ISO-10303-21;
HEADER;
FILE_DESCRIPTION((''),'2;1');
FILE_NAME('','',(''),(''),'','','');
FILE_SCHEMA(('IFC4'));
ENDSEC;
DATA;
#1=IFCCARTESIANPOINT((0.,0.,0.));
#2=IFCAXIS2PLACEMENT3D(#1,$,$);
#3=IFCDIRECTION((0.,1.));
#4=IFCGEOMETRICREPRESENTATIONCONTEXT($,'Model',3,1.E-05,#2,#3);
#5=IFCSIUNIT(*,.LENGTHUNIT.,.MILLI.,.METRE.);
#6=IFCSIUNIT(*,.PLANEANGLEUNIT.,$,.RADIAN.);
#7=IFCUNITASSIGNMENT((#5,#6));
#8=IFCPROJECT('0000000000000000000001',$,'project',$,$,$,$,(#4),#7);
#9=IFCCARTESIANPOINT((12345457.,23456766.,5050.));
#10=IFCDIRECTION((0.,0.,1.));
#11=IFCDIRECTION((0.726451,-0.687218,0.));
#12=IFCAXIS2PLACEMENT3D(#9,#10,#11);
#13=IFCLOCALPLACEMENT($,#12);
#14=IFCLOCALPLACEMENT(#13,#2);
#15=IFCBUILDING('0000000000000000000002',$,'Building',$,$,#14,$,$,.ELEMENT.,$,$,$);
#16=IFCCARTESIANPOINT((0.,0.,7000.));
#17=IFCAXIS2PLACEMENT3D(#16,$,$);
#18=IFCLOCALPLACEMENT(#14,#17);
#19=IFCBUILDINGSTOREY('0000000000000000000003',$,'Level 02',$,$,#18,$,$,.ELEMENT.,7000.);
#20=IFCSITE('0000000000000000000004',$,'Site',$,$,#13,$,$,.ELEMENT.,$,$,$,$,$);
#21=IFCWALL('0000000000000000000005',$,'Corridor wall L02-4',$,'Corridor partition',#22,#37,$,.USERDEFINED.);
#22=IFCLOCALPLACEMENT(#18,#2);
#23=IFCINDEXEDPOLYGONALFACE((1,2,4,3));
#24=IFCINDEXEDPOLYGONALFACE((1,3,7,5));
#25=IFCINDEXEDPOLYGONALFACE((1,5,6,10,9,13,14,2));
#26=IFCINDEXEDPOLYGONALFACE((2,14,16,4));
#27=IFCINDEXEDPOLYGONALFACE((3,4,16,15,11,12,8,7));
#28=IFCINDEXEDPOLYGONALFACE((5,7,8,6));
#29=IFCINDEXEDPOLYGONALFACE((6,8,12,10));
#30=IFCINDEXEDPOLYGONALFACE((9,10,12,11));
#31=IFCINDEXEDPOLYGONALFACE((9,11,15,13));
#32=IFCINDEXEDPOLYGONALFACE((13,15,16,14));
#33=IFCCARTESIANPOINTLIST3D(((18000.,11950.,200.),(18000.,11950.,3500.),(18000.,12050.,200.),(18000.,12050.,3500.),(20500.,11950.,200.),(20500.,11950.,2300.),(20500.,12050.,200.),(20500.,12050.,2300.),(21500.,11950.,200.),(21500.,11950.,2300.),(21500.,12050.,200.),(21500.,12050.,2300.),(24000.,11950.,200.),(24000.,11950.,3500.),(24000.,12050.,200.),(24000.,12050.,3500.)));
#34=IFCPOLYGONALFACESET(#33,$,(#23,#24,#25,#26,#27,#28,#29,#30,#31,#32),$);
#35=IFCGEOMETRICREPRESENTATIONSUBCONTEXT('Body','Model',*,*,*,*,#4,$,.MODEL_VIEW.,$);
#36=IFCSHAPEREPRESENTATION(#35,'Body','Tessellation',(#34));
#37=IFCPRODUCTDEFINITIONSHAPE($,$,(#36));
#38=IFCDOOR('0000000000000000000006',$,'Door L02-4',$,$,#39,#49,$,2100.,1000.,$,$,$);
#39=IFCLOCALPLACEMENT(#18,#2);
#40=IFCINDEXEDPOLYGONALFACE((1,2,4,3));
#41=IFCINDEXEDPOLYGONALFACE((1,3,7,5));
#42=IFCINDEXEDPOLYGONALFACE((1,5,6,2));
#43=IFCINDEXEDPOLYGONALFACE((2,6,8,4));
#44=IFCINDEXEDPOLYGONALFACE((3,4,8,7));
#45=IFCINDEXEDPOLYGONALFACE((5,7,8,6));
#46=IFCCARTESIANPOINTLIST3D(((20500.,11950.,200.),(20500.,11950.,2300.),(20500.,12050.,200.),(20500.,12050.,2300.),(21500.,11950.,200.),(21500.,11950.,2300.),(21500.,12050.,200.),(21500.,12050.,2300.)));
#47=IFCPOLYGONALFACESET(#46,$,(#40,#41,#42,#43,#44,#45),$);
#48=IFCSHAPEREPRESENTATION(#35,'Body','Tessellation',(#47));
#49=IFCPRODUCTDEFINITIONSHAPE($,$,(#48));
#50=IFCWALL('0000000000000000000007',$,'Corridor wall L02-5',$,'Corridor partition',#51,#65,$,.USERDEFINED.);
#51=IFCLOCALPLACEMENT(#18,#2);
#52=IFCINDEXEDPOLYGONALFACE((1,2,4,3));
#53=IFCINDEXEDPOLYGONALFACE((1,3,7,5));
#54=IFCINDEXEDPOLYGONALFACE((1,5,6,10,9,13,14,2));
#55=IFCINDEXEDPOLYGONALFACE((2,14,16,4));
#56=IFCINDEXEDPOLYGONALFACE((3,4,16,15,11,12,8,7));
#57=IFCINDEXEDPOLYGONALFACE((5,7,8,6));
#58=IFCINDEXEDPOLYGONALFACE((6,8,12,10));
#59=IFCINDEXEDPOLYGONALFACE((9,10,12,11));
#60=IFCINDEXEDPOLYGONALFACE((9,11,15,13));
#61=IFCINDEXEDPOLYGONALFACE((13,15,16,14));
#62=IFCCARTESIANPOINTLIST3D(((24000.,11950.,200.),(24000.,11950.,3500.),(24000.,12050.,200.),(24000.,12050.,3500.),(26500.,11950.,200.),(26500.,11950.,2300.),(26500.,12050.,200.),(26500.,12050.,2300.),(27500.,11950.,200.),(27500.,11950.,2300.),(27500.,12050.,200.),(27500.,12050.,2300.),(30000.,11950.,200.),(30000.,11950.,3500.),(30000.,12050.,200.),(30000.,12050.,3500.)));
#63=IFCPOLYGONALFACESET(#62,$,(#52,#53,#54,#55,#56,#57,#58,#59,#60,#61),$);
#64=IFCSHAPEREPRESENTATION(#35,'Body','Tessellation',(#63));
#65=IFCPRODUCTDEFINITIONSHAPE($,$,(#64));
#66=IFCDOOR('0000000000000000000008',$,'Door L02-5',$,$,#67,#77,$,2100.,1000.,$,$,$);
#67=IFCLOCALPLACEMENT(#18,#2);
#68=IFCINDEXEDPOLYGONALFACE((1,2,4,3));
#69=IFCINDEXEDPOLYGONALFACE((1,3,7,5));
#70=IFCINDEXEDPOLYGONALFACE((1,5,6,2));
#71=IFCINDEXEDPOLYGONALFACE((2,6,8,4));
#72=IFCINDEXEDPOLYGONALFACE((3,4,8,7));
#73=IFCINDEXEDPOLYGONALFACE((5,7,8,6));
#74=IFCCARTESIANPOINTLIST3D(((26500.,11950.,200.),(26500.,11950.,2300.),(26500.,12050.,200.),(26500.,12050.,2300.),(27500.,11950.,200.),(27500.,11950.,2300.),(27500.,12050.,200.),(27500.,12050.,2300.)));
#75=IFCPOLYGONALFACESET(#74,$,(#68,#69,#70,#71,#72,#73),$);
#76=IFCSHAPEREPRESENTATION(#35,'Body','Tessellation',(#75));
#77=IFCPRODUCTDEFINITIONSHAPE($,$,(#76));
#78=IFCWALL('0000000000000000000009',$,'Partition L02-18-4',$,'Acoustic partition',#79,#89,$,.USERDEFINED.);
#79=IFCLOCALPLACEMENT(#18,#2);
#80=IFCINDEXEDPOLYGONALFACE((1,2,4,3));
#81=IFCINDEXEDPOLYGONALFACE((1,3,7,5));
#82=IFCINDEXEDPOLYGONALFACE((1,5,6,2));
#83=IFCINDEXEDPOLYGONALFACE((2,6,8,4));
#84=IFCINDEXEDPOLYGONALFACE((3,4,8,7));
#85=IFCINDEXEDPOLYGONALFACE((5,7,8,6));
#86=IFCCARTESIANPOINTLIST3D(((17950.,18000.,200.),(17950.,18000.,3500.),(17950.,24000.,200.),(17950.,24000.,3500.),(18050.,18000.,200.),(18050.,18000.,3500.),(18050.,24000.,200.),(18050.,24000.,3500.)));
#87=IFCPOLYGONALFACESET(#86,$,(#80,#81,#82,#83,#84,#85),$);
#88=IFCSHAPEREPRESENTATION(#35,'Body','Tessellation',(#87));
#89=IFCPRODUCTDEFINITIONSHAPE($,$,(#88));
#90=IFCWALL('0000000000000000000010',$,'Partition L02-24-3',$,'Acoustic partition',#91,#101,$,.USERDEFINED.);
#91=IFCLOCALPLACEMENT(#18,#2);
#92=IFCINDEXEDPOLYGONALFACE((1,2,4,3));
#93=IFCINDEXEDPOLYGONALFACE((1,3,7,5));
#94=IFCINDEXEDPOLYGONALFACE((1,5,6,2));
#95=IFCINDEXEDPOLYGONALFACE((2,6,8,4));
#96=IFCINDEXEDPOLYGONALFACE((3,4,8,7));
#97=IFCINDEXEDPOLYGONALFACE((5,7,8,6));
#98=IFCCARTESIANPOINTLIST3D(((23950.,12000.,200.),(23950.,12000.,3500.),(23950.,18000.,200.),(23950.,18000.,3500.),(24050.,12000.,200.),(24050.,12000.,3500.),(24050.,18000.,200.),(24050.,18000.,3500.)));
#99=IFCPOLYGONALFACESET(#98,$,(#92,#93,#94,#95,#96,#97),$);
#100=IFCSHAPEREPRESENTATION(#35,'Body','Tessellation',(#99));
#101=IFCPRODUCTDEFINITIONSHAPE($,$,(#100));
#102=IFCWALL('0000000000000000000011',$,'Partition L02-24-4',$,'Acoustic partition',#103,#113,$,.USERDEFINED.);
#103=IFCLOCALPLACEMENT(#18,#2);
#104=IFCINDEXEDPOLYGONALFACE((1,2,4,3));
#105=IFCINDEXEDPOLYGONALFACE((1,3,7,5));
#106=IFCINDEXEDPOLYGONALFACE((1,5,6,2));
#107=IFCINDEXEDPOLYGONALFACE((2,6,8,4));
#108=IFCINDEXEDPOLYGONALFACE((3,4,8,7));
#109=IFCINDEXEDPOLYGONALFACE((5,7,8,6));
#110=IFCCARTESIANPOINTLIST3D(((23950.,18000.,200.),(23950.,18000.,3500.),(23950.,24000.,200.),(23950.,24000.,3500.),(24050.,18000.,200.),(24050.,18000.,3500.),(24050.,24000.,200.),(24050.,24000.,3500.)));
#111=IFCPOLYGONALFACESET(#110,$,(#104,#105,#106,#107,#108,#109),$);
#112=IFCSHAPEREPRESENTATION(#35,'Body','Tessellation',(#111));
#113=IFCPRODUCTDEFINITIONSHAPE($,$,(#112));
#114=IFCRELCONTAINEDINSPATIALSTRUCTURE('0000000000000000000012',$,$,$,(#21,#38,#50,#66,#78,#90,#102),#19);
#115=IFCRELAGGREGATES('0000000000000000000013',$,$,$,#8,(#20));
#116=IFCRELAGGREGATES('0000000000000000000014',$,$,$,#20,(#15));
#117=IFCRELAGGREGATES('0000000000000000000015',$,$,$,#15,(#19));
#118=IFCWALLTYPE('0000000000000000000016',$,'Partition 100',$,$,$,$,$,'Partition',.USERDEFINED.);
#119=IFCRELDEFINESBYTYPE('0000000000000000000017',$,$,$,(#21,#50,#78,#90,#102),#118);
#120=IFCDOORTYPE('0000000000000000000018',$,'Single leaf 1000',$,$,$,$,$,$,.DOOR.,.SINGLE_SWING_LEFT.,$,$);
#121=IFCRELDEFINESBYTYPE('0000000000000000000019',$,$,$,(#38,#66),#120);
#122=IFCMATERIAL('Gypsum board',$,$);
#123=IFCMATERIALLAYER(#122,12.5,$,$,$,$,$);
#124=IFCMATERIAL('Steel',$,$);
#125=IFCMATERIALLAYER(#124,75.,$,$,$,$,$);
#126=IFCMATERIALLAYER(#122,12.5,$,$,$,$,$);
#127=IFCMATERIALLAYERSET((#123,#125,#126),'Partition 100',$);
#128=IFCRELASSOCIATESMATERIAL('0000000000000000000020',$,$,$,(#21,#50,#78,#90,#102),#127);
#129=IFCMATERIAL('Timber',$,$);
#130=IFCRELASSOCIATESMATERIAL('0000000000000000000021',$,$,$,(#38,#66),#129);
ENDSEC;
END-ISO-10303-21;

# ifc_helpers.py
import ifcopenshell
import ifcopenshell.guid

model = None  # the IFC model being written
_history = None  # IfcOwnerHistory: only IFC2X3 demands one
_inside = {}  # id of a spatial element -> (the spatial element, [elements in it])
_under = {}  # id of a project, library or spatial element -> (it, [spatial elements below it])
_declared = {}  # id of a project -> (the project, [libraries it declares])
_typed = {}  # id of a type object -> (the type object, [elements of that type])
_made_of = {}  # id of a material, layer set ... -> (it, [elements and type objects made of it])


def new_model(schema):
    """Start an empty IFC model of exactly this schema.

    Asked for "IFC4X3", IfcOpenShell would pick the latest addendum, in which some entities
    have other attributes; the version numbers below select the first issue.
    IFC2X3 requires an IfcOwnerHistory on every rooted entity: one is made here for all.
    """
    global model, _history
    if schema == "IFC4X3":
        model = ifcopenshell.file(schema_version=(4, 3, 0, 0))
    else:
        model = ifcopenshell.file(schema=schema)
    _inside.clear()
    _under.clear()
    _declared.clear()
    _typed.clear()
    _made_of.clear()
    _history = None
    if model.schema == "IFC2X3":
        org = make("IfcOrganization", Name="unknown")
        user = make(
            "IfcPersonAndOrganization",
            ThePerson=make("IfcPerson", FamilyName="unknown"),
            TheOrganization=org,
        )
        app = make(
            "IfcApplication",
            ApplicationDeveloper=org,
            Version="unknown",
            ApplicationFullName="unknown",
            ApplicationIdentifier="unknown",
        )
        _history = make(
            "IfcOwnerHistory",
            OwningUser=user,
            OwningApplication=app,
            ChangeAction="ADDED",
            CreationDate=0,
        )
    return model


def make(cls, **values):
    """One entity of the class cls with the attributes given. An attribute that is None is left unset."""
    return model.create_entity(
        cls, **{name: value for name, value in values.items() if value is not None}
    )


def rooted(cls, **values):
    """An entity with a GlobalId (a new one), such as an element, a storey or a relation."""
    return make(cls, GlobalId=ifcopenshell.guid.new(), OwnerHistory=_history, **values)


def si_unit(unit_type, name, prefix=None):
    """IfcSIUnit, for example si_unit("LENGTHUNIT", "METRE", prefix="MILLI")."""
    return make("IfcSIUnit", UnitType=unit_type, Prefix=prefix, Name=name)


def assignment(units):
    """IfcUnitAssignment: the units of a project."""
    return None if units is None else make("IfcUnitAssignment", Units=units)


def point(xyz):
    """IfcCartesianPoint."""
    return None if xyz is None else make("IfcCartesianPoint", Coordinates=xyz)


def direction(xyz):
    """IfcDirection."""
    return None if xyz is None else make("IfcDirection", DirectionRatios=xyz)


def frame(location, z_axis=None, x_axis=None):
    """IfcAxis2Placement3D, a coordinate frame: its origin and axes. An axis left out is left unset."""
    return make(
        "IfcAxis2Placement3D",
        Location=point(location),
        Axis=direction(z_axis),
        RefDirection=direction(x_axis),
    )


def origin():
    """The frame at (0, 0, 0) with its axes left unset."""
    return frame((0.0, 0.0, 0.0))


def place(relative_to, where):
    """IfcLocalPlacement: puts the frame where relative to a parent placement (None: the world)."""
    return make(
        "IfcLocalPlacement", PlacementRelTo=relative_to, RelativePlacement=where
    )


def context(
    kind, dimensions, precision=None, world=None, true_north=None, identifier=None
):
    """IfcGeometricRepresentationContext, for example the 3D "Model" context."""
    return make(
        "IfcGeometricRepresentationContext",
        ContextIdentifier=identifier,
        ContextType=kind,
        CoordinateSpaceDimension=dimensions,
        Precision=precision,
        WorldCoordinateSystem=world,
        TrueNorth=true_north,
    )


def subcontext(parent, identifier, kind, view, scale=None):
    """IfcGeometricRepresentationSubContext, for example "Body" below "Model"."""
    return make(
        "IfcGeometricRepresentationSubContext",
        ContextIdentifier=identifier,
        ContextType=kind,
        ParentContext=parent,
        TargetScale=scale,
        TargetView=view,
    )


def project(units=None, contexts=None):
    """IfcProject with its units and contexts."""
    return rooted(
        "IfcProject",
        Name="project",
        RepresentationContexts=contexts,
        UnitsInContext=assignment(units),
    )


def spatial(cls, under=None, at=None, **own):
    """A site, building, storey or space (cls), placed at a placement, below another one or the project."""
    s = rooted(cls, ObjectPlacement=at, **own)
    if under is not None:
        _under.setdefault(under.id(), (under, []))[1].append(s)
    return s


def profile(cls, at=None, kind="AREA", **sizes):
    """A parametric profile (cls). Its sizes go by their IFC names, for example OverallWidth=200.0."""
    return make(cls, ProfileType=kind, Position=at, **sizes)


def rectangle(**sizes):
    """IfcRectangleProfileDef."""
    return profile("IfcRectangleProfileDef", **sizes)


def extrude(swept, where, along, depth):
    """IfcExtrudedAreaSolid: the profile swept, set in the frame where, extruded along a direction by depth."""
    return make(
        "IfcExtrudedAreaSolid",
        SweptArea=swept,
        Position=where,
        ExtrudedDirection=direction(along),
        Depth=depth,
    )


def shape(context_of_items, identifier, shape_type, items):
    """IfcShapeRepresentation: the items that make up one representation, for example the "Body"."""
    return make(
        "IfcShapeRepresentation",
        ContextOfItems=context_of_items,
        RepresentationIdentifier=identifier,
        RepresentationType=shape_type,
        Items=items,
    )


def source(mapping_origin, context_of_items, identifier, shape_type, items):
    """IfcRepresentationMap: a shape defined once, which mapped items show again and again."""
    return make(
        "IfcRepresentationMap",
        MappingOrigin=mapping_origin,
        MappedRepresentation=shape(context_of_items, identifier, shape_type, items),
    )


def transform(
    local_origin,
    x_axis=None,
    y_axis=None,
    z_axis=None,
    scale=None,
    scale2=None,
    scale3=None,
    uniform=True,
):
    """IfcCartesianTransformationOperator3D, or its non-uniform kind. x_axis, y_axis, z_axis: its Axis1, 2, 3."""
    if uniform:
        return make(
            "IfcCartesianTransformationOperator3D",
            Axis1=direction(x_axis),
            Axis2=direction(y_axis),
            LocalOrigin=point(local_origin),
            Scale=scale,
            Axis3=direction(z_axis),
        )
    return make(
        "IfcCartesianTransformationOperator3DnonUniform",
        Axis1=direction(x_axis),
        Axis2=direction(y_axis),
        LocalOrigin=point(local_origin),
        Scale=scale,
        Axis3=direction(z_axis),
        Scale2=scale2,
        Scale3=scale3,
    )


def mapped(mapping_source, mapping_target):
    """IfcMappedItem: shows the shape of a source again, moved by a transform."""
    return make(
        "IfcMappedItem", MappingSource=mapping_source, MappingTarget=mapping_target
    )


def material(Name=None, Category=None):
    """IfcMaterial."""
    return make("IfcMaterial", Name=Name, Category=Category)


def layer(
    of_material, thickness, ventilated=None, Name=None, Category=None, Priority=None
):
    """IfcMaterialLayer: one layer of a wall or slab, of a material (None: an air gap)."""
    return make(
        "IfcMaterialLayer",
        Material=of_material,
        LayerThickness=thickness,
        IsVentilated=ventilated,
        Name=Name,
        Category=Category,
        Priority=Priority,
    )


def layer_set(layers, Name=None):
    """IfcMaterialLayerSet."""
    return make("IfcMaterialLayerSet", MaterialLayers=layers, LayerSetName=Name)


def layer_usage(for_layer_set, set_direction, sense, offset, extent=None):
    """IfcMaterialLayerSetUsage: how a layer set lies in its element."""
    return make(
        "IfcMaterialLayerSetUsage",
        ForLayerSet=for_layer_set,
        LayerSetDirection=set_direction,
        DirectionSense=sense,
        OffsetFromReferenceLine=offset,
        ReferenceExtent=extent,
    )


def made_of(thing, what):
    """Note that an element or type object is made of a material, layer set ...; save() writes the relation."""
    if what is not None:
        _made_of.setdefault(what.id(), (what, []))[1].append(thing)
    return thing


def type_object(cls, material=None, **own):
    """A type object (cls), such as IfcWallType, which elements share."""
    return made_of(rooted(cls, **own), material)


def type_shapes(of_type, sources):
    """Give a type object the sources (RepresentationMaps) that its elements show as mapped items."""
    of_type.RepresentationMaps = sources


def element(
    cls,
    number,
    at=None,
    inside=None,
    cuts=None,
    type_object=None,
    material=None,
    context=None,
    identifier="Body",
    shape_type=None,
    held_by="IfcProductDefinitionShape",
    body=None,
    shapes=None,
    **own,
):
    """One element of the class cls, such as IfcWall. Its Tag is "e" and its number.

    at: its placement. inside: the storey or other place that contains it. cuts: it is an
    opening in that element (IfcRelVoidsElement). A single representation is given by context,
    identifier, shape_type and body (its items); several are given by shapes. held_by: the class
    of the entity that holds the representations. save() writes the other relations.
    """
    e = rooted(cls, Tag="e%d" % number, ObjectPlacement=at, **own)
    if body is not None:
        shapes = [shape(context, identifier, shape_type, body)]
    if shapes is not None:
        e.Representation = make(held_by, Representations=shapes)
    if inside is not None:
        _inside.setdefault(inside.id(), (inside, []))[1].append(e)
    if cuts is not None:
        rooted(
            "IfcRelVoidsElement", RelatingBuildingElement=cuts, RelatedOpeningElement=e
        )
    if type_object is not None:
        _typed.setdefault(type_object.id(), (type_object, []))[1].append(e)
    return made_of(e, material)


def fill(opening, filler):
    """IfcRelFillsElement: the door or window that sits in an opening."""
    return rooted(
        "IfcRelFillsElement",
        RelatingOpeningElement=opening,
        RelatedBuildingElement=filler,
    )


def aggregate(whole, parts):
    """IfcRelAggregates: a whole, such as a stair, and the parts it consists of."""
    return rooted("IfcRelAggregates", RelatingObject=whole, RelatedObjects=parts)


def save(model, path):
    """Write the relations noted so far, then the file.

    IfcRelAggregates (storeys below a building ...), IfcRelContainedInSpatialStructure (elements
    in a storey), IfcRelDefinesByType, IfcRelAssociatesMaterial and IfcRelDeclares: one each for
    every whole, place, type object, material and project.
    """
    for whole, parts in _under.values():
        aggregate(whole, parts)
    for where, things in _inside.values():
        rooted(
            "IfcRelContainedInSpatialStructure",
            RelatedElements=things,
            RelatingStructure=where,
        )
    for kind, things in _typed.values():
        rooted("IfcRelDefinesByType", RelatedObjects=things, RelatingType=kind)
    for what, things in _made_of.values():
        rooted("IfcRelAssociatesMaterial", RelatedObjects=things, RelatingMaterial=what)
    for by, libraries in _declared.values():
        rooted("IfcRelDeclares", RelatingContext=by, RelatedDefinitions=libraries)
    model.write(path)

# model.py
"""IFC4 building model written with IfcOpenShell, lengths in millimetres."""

from ifc_helpers import new_model, si_unit, direction, frame, origin, place, context, subcontext, project, spatial, rectangle, extrude, source, transform, mapped, material, layer, layer_set, layer_usage, type_object, type_shapes, element, fill, save


model = new_model("IFC4")

# Units and contexts
model_context = context("Model", 3, precision=1e-05, world=origin(), true_north=direction((0.0, 1.0)))
body_context = subcontext(model_context, "Body", "Model", "MODEL_VIEW")
ifc_project = project(units=[si_unit("LENGTHUNIT", "METRE", prefix="MILLI"), si_unit("PLANEANGLEUNIT", "RADIAN")], contexts=[model_context])

# Site, building, storey
site_placement = place(None, frame((12345457.0, 23456766.0, 5050.0), z_axis=(0.0, 0.0, 1.0), x_axis=(0.726451, -0.687218, 0.0)))
site = spatial("IfcSite", under=ifc_project, at=site_placement, Name="Site", CompositionType="ELEMENT")
building_placement = place(site_placement, origin())
building = spatial("IfcBuilding", under=site, at=building_placement, Name="Building", CompositionType="ELEMENT")
storey_placement = place(building_placement, frame((0.0, 0.0, 7000.0)))
storey = spatial("IfcBuildingStorey", under=building, at=storey_placement, Name="Level 02", CompositionType="ELEMENT", Elevation=7000.0)

# Shared definitions
ifc_material_1 = material(Name="Steel")

# Walls, openings, doors
ifc_material_2 = material(Name="Gypsum board")
ifc_layer_1 = layer(ifc_material_2, 12.5)
ifc_layer_2 = layer(ifc_material_1, 75.0)
ifc_layer_3 = layer(ifc_material_2, 12.5)
ifc_layer_set_1 = layer_set([ifc_layer_1, ifc_layer_2, ifc_layer_3], Name="Partition 100")
ifc_layer_usage_1 = layer_usage(ifc_layer_set_1, "AXIS2", "POSITIVE", 0.0)
wall_type_1 = type_object("IfcWallType", Name="Partition 100", ElementType="Partition", PredefinedType="USERDEFINED")
wall_1_placement = place(storey_placement, frame((18000.0, 11950.0, 200.0)))
wall_1 = element("IfcWall", 1, at=wall_1_placement, inside=storey, type_object=wall_type_1, material=ifc_layer_usage_1, Name="Corridor wall L02-4", ObjectType="Corridor partition", PredefinedType="USERDEFINED", context=body_context, shape_type="SweptSolid", body=[
    extrude(rectangle(XDim=6000.0, YDim=100.0), frame((3000.0, 50.0, 0.0)), (0.0, 0.0, 1.0), 3300.0),
])
opening_1_placement = place(wall_1_placement, frame((2500.0, -50.0, 0.0)))
opening_1 = element("IfcOpeningElement", 2, at=opening_1_placement, cuts=wall_1, PredefinedType="OPENING", context=body_context, shape_type="SweptSolid", body=[
    extrude(rectangle(XDim=1000.0, YDim=200.0), frame((500.0, 100.0, 0.0)), (0.0, 0.0, 1.0), 2100.0),
])
ifc_material_3 = material(Name="Timber")
door_type = type_object("IfcDoorType", Name="Single leaf 1000", OperationType="SINGLE_SWING_LEFT", PredefinedType="DOOR")
shared_shape = source(origin(), body_context, "Body", "SweptSolid", [
    extrude(rectangle(XDim=1000.0, YDim=100.0), frame((500.0, 50.0, 0.0)), (0.0, 0.0, 1.0), 2100.0),
])
type_shapes(door_type, [shared_shape])
door_1_placement = place(storey_placement, frame((20500.0, 11950.0, 200.0)))
door_1 = element("IfcDoor", 3, at=door_1_placement, inside=storey, type_object=door_type, material=ifc_material_3, Name="Door L02-4", OverallHeight=2100.0, OverallWidth=1000.0, context=body_context, shape_type="MappedRepresentation", body=[
    mapped(shared_shape, transform((0.0, 0.0, 0.0))),
])
fill(opening_1, door_1)
wall_2_placement = place(storey_placement, frame((24000.0, 11950.0, 200.0)))
wall_2 = element("IfcWall", 4, at=wall_2_placement, inside=storey, type_object=wall_type_1, material=ifc_layer_usage_1, Name="Corridor wall L02-5", ObjectType="Corridor partition", PredefinedType="USERDEFINED", context=body_context, shape_type="SweptSolid", body=[
    extrude(rectangle(XDim=6000.0, YDim=100.0), frame((3000.0, 50.0, 0.0)), (0.0, 0.0, 1.0), 3300.0),
])
opening_2_placement = place(wall_2_placement, frame((2500.0, -50.0, 0.0)))
opening_2 = element("IfcOpeningElement", 5, at=opening_2_placement, cuts=wall_2, PredefinedType="OPENING", context=body_context, shape_type="SweptSolid", body=[
    extrude(rectangle(XDim=1000.0, YDim=200.0), frame((500.0, 100.0, 0.0)), (0.0, 0.0, 1.0), 2100.0),
])
door_2_placement = place(storey_placement, frame((26500.0, 11950.0, 200.0)))
door_2 = element("IfcDoor", 6, at=door_2_placement, inside=storey, type_object=door_type, material=ifc_material_3, Name="Door L02-5", OverallHeight=2100.0, OverallWidth=1000.0, context=body_context, shape_type="MappedRepresentation", body=[
    mapped(shared_shape, transform((0.0, 0.0, 0.0))),
])
fill(opening_2, door_2)

# Walls
for number, where, name in (
    (7, (17950.0, 18000.0, 200.0), "Partition L02-18-4"),
    (8, (23950.0, 12000.0, 200.0), "Partition L02-24-3"),
    (9, (23950.0, 18000.0, 200.0), "Partition L02-24-4"),
):
    element("IfcWall", number, at=place(storey_placement, frame(where)), inside=storey, type_object=wall_type_1, material=ifc_layer_usage_1, Name=name, ObjectType="Acoustic partition", PredefinedType="USERDEFINED", context=body_context, shape_type="SweptSolid", body=[
        extrude(rectangle(XDim=100.0, YDim=6000.0), frame((50.0, 3000.0, 0.0)), (0.0, 0.0, 1.0), 3300.0),
    ])

save(model, "model.ifc")
